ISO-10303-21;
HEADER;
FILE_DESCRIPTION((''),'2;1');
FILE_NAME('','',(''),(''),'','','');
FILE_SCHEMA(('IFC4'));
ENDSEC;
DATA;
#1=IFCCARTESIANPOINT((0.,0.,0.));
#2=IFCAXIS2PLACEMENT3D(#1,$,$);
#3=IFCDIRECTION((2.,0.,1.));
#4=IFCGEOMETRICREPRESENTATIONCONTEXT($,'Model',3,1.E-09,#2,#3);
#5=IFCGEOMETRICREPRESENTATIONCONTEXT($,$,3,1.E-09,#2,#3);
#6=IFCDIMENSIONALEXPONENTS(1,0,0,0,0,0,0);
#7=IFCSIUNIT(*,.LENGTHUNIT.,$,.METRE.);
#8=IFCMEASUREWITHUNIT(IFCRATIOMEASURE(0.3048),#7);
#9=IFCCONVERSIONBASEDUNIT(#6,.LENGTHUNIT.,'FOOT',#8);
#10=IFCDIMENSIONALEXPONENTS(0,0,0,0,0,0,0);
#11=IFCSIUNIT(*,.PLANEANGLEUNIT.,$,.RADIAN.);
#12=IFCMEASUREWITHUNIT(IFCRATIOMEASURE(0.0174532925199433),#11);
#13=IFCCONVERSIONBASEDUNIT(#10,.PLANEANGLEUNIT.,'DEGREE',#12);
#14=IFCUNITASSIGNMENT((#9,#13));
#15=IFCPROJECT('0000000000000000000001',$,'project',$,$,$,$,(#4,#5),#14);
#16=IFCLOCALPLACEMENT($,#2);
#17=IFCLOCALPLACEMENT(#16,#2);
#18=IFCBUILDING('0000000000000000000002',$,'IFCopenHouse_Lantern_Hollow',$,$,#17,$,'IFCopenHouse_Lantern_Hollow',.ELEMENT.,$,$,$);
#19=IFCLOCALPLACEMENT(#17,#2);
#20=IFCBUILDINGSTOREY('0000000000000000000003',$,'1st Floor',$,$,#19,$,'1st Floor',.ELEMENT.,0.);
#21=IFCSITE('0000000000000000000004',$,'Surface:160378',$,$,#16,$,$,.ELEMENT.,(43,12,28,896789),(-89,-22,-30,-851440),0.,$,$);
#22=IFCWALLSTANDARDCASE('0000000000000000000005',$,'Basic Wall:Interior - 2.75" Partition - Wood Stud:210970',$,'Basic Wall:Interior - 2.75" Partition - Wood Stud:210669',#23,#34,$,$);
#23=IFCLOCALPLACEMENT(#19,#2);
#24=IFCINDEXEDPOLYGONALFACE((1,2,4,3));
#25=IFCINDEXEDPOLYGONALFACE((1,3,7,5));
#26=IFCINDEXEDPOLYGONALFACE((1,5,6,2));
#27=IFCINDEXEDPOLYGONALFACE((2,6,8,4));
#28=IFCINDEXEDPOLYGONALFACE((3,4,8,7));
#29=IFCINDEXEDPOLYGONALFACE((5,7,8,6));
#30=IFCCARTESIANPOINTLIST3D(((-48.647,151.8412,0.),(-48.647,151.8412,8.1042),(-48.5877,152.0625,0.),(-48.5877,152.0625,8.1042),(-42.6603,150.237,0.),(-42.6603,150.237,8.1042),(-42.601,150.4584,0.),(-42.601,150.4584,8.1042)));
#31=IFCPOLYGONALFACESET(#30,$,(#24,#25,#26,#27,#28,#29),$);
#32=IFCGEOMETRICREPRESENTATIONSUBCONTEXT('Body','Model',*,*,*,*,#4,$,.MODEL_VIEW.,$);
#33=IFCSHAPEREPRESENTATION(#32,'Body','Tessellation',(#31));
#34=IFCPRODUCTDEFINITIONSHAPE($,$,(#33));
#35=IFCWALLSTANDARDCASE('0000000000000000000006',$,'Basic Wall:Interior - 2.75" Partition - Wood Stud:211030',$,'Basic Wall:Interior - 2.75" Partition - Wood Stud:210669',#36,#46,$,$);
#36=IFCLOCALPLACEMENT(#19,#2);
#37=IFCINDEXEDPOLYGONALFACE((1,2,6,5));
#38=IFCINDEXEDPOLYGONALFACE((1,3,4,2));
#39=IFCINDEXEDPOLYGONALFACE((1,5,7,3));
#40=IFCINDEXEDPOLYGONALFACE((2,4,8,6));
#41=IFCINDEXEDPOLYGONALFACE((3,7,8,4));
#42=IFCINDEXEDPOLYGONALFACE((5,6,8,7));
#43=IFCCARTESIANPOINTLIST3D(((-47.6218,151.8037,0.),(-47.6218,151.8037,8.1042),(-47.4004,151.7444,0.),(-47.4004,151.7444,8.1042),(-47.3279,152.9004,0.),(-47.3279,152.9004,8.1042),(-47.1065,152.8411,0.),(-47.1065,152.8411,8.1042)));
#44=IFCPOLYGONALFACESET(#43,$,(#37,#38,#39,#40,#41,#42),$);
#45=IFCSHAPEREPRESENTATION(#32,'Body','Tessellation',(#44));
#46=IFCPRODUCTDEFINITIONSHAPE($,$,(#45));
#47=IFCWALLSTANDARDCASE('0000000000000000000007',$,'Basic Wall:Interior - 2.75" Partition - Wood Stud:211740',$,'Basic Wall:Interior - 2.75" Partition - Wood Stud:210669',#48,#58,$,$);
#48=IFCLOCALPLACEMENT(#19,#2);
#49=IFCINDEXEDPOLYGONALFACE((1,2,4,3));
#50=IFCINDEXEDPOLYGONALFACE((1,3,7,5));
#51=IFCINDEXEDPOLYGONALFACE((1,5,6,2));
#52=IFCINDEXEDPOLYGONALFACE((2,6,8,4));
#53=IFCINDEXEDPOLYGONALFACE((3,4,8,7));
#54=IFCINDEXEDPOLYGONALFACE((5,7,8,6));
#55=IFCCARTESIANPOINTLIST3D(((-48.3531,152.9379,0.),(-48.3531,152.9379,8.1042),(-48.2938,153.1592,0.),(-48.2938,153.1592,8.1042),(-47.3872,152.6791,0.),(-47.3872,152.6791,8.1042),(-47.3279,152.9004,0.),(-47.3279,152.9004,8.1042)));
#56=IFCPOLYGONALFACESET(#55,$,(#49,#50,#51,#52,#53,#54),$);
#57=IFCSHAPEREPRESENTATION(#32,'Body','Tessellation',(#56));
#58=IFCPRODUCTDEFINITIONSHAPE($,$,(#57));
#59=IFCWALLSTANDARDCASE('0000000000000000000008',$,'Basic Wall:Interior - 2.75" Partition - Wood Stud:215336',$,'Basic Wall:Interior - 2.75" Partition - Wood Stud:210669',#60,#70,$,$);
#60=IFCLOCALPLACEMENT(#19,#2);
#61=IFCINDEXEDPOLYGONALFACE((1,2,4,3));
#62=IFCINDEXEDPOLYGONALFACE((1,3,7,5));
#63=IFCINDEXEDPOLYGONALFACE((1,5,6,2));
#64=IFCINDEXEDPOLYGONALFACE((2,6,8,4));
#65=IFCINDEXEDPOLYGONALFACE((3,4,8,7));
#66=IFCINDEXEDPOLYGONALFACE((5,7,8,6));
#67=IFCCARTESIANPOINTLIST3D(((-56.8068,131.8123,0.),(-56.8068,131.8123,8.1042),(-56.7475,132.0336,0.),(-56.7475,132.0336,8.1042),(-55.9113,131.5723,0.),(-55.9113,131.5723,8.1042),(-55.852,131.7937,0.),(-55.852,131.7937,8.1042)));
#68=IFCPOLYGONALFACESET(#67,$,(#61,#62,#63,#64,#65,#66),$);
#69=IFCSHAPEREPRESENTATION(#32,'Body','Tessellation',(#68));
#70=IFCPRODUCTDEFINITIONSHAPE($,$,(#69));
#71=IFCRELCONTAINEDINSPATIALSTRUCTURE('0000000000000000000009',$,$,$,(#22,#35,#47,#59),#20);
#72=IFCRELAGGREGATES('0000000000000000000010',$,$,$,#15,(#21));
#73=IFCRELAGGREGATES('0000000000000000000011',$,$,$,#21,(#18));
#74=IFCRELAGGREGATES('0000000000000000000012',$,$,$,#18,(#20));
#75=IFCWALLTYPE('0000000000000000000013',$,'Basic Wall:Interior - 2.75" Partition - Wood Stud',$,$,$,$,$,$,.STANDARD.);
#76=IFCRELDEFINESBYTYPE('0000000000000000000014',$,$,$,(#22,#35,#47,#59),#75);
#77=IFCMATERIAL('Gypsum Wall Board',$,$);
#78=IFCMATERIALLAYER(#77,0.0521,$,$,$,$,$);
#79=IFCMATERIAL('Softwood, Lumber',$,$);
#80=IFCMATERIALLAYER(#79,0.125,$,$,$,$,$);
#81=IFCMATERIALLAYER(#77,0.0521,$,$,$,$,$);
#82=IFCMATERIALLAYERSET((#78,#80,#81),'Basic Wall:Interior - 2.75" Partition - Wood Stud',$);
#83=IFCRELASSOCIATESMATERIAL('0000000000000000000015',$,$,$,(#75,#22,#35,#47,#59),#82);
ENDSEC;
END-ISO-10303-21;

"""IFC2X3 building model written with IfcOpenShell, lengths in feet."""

from ifc_helpers import new_model, entity, si_unit, converted_unit, direction, frame, frame_2d, origin, place, context, subcontext, project, spatial, rectangle, extrude, material, layer, layer_set, layer_usage, type_object, element, save


model = new_model("IFC2X3")

# Units and contexts
model_context = context("Model", 3, precision=1e-09, world=origin(), true_north=direction((2.0, 0.0, 1.0)))
context_of_model = context(None, 3, precision=1e-09, world=origin(), true_north=direction((2.0, 0.0, 1.0)))
body_context = subcontext(model_context, "Body", "Model", "MODEL_VIEW")
ifc_project = project(units=[converted_unit("LENGTHUNIT", "FOOT", entity("IfcRatioMeasure", 0.3048), si_unit("LENGTHUNIT", "METRE"), dimensions=[1, 0, 0, 0, 0, 0, 0]), converted_unit("PLANEANGLEUNIT", "DEGREE", entity("IfcRatioMeasure", 0.0174532925199433), si_unit("PLANEANGLEUNIT", "RADIAN"), dimensions=[0, 0, 0, 0, 0, 0, 0])], contexts=[model_context, context_of_model])

# Site, building, storey
site_placement = place(None, origin())
site = spatial("IfcSite", under=ifc_project, at=site_placement, Name="Surface:160378", CompositionType="ELEMENT", RefLatitude=(43, 12, 28, 896789), RefLongitude=(-89, -22, -30, -851440), RefElevation=0.0)
building_placement = place(site_placement, origin())
building = spatial("IfcBuilding", under=site, at=building_placement, Name="IFCopenHouse_Lantern_Hollow", LongName="IFCopenHouse_Lantern_Hollow", CompositionType="ELEMENT")
storey_placement = place(building_placement, origin())
storey = spatial("IfcBuildingStorey", under=building, at=storey_placement, Name="1st Floor", LongName="1st Floor", CompositionType="ELEMENT", Elevation=0.0)

# Shared definitions
ifc_material_1 = material(Name="Gypsum Wall Board")
ifc_material_2 = material(Name="Softwood, Lumber")

# Walls
ifc_layer_1 = layer(ifc_material_1, 0.0521)
ifc_layer_2 = layer(ifc_material_2, 0.125)
ifc_layer_3 = layer(ifc_material_1, 0.0521)
ifc_layer_set_1 = layer_set([ifc_layer_1, ifc_layer_2, ifc_layer_3], Name="Basic Wall:Interior - 2.75\" Partition - Wood Stud")
wall_type_1 = type_object("IfcWallType", Name="Basic Wall:Interior - 2.75\" Partition - Wood Stud", PredefinedType="STANDARD", material=ifc_layer_set_1)
ifc_layer_usage_1 = layer_usage(ifc_layer_set_1, "AXIS2", "NEGATIVE", 0.1146)
wall_1_placement = place(storey_placement, frame((-48.6174, 151.9518, 0.0), z_axis=(0.0, 0.0, 1.0), x_axis=(0.965926, -0.258819, 0.0)))
element("IfcWallStandardCase", 1, at=wall_1_placement, inside=storey, type_object=wall_type_1, material=ifc_layer_usage_1, Name="Basic Wall:Interior - 2.75\" Partition - Wood Stud:210970", ObjectType="Basic Wall:Interior - 2.75\" Partition - Wood Stud:210669", context=body_context, shape_type="SweptSolid", body=[
    extrude(rectangle(XDim=6.1979, YDim=0.2292, at=frame_2d((3.099, 0.0), x_axis=(-1.0, 0.0))), origin(), (0.0, 0.0, 1.0), 8.1042),
])
ifc_layer_usage_2 = layer_usage(ifc_layer_set_1, "AXIS2", "NEGATIVE", 0.1146)
wall_2_placement = place(storey_placement, frame((-47.5111, 151.774, 0.0), z_axis=(0.0, 0.0, 1.0), x_axis=(0.258819, 0.965926, 0.0)))
element("IfcWallStandardCase", 2, at=wall_2_placement, inside=storey, type_object=wall_type_1, material=ifc_layer_usage_2, Name="Basic Wall:Interior - 2.75\" Partition - Wood Stud:211030", ObjectType="Basic Wall:Interior - 2.75\" Partition - Wood Stud:210669", context=body_context, shape_type="SweptSolid", body=[
    extrude(rectangle(XDim=1.1354, YDim=0.2292, at=frame_2d((0.5677, 0.0), x_axis=(-1.0, 0.0))), origin(), (0.0, 0.0, 1.0), 8.1042),
])
ifc_layer_usage_3 = layer_usage(ifc_layer_set_1, "AXIS2", "NEGATIVE", 0.1146)
wall_3_placement = place(storey_placement, frame((-48.3235, 153.0486, 0.0), z_axis=(0.0, 0.0, 1.0), x_axis=(0.965926, -0.258819, 0.0)))
element("IfcWallStandardCase", 3, at=wall_3_placement, inside=storey, type_object=wall_type_1, material=ifc_layer_usage_3, Name="Basic Wall:Interior - 2.75\" Partition - Wood Stud:211740", ObjectType="Basic Wall:Interior - 2.75\" Partition - Wood Stud:210669", context=body_context, shape_type="SweptSolid", body=[
    extrude(rectangle(XDim=1.0, YDim=0.2292, at=frame_2d((0.5, 0.0), x_axis=(-1.0, 0.0))), origin(), (0.0, 0.0, 1.0), 8.1042),
])
ifc_layer_usage_4 = layer_usage(ifc_layer_set_1, "AXIS2", "NEGATIVE", 0.1146)
wall_4_placement = place(storey_placement, frame((-56.7772, 131.923, 0.0), z_axis=(0.0, 0.0, 1.0), x_axis=(0.965926, -0.258819, 0.0)))
element("IfcWallStandardCase", 4, at=wall_4_placement, inside=storey, type_object=wall_type_1, material=ifc_layer_usage_4, Name="Basic Wall:Interior - 2.75\" Partition - Wood Stud:215336", ObjectType="Basic Wall:Interior - 2.75\" Partition - Wood Stud:210669", context=body_context, shape_type="SweptSolid", body=[
    extrude(rectangle(XDim=0.9271, YDim=0.2292, at=frame_2d((0.4635, 0.0), x_axis=(-1.0, 0.0))), origin(), (0.0, 0.0, 1.0), 8.1042),
])

save(model, "model.ifc")
